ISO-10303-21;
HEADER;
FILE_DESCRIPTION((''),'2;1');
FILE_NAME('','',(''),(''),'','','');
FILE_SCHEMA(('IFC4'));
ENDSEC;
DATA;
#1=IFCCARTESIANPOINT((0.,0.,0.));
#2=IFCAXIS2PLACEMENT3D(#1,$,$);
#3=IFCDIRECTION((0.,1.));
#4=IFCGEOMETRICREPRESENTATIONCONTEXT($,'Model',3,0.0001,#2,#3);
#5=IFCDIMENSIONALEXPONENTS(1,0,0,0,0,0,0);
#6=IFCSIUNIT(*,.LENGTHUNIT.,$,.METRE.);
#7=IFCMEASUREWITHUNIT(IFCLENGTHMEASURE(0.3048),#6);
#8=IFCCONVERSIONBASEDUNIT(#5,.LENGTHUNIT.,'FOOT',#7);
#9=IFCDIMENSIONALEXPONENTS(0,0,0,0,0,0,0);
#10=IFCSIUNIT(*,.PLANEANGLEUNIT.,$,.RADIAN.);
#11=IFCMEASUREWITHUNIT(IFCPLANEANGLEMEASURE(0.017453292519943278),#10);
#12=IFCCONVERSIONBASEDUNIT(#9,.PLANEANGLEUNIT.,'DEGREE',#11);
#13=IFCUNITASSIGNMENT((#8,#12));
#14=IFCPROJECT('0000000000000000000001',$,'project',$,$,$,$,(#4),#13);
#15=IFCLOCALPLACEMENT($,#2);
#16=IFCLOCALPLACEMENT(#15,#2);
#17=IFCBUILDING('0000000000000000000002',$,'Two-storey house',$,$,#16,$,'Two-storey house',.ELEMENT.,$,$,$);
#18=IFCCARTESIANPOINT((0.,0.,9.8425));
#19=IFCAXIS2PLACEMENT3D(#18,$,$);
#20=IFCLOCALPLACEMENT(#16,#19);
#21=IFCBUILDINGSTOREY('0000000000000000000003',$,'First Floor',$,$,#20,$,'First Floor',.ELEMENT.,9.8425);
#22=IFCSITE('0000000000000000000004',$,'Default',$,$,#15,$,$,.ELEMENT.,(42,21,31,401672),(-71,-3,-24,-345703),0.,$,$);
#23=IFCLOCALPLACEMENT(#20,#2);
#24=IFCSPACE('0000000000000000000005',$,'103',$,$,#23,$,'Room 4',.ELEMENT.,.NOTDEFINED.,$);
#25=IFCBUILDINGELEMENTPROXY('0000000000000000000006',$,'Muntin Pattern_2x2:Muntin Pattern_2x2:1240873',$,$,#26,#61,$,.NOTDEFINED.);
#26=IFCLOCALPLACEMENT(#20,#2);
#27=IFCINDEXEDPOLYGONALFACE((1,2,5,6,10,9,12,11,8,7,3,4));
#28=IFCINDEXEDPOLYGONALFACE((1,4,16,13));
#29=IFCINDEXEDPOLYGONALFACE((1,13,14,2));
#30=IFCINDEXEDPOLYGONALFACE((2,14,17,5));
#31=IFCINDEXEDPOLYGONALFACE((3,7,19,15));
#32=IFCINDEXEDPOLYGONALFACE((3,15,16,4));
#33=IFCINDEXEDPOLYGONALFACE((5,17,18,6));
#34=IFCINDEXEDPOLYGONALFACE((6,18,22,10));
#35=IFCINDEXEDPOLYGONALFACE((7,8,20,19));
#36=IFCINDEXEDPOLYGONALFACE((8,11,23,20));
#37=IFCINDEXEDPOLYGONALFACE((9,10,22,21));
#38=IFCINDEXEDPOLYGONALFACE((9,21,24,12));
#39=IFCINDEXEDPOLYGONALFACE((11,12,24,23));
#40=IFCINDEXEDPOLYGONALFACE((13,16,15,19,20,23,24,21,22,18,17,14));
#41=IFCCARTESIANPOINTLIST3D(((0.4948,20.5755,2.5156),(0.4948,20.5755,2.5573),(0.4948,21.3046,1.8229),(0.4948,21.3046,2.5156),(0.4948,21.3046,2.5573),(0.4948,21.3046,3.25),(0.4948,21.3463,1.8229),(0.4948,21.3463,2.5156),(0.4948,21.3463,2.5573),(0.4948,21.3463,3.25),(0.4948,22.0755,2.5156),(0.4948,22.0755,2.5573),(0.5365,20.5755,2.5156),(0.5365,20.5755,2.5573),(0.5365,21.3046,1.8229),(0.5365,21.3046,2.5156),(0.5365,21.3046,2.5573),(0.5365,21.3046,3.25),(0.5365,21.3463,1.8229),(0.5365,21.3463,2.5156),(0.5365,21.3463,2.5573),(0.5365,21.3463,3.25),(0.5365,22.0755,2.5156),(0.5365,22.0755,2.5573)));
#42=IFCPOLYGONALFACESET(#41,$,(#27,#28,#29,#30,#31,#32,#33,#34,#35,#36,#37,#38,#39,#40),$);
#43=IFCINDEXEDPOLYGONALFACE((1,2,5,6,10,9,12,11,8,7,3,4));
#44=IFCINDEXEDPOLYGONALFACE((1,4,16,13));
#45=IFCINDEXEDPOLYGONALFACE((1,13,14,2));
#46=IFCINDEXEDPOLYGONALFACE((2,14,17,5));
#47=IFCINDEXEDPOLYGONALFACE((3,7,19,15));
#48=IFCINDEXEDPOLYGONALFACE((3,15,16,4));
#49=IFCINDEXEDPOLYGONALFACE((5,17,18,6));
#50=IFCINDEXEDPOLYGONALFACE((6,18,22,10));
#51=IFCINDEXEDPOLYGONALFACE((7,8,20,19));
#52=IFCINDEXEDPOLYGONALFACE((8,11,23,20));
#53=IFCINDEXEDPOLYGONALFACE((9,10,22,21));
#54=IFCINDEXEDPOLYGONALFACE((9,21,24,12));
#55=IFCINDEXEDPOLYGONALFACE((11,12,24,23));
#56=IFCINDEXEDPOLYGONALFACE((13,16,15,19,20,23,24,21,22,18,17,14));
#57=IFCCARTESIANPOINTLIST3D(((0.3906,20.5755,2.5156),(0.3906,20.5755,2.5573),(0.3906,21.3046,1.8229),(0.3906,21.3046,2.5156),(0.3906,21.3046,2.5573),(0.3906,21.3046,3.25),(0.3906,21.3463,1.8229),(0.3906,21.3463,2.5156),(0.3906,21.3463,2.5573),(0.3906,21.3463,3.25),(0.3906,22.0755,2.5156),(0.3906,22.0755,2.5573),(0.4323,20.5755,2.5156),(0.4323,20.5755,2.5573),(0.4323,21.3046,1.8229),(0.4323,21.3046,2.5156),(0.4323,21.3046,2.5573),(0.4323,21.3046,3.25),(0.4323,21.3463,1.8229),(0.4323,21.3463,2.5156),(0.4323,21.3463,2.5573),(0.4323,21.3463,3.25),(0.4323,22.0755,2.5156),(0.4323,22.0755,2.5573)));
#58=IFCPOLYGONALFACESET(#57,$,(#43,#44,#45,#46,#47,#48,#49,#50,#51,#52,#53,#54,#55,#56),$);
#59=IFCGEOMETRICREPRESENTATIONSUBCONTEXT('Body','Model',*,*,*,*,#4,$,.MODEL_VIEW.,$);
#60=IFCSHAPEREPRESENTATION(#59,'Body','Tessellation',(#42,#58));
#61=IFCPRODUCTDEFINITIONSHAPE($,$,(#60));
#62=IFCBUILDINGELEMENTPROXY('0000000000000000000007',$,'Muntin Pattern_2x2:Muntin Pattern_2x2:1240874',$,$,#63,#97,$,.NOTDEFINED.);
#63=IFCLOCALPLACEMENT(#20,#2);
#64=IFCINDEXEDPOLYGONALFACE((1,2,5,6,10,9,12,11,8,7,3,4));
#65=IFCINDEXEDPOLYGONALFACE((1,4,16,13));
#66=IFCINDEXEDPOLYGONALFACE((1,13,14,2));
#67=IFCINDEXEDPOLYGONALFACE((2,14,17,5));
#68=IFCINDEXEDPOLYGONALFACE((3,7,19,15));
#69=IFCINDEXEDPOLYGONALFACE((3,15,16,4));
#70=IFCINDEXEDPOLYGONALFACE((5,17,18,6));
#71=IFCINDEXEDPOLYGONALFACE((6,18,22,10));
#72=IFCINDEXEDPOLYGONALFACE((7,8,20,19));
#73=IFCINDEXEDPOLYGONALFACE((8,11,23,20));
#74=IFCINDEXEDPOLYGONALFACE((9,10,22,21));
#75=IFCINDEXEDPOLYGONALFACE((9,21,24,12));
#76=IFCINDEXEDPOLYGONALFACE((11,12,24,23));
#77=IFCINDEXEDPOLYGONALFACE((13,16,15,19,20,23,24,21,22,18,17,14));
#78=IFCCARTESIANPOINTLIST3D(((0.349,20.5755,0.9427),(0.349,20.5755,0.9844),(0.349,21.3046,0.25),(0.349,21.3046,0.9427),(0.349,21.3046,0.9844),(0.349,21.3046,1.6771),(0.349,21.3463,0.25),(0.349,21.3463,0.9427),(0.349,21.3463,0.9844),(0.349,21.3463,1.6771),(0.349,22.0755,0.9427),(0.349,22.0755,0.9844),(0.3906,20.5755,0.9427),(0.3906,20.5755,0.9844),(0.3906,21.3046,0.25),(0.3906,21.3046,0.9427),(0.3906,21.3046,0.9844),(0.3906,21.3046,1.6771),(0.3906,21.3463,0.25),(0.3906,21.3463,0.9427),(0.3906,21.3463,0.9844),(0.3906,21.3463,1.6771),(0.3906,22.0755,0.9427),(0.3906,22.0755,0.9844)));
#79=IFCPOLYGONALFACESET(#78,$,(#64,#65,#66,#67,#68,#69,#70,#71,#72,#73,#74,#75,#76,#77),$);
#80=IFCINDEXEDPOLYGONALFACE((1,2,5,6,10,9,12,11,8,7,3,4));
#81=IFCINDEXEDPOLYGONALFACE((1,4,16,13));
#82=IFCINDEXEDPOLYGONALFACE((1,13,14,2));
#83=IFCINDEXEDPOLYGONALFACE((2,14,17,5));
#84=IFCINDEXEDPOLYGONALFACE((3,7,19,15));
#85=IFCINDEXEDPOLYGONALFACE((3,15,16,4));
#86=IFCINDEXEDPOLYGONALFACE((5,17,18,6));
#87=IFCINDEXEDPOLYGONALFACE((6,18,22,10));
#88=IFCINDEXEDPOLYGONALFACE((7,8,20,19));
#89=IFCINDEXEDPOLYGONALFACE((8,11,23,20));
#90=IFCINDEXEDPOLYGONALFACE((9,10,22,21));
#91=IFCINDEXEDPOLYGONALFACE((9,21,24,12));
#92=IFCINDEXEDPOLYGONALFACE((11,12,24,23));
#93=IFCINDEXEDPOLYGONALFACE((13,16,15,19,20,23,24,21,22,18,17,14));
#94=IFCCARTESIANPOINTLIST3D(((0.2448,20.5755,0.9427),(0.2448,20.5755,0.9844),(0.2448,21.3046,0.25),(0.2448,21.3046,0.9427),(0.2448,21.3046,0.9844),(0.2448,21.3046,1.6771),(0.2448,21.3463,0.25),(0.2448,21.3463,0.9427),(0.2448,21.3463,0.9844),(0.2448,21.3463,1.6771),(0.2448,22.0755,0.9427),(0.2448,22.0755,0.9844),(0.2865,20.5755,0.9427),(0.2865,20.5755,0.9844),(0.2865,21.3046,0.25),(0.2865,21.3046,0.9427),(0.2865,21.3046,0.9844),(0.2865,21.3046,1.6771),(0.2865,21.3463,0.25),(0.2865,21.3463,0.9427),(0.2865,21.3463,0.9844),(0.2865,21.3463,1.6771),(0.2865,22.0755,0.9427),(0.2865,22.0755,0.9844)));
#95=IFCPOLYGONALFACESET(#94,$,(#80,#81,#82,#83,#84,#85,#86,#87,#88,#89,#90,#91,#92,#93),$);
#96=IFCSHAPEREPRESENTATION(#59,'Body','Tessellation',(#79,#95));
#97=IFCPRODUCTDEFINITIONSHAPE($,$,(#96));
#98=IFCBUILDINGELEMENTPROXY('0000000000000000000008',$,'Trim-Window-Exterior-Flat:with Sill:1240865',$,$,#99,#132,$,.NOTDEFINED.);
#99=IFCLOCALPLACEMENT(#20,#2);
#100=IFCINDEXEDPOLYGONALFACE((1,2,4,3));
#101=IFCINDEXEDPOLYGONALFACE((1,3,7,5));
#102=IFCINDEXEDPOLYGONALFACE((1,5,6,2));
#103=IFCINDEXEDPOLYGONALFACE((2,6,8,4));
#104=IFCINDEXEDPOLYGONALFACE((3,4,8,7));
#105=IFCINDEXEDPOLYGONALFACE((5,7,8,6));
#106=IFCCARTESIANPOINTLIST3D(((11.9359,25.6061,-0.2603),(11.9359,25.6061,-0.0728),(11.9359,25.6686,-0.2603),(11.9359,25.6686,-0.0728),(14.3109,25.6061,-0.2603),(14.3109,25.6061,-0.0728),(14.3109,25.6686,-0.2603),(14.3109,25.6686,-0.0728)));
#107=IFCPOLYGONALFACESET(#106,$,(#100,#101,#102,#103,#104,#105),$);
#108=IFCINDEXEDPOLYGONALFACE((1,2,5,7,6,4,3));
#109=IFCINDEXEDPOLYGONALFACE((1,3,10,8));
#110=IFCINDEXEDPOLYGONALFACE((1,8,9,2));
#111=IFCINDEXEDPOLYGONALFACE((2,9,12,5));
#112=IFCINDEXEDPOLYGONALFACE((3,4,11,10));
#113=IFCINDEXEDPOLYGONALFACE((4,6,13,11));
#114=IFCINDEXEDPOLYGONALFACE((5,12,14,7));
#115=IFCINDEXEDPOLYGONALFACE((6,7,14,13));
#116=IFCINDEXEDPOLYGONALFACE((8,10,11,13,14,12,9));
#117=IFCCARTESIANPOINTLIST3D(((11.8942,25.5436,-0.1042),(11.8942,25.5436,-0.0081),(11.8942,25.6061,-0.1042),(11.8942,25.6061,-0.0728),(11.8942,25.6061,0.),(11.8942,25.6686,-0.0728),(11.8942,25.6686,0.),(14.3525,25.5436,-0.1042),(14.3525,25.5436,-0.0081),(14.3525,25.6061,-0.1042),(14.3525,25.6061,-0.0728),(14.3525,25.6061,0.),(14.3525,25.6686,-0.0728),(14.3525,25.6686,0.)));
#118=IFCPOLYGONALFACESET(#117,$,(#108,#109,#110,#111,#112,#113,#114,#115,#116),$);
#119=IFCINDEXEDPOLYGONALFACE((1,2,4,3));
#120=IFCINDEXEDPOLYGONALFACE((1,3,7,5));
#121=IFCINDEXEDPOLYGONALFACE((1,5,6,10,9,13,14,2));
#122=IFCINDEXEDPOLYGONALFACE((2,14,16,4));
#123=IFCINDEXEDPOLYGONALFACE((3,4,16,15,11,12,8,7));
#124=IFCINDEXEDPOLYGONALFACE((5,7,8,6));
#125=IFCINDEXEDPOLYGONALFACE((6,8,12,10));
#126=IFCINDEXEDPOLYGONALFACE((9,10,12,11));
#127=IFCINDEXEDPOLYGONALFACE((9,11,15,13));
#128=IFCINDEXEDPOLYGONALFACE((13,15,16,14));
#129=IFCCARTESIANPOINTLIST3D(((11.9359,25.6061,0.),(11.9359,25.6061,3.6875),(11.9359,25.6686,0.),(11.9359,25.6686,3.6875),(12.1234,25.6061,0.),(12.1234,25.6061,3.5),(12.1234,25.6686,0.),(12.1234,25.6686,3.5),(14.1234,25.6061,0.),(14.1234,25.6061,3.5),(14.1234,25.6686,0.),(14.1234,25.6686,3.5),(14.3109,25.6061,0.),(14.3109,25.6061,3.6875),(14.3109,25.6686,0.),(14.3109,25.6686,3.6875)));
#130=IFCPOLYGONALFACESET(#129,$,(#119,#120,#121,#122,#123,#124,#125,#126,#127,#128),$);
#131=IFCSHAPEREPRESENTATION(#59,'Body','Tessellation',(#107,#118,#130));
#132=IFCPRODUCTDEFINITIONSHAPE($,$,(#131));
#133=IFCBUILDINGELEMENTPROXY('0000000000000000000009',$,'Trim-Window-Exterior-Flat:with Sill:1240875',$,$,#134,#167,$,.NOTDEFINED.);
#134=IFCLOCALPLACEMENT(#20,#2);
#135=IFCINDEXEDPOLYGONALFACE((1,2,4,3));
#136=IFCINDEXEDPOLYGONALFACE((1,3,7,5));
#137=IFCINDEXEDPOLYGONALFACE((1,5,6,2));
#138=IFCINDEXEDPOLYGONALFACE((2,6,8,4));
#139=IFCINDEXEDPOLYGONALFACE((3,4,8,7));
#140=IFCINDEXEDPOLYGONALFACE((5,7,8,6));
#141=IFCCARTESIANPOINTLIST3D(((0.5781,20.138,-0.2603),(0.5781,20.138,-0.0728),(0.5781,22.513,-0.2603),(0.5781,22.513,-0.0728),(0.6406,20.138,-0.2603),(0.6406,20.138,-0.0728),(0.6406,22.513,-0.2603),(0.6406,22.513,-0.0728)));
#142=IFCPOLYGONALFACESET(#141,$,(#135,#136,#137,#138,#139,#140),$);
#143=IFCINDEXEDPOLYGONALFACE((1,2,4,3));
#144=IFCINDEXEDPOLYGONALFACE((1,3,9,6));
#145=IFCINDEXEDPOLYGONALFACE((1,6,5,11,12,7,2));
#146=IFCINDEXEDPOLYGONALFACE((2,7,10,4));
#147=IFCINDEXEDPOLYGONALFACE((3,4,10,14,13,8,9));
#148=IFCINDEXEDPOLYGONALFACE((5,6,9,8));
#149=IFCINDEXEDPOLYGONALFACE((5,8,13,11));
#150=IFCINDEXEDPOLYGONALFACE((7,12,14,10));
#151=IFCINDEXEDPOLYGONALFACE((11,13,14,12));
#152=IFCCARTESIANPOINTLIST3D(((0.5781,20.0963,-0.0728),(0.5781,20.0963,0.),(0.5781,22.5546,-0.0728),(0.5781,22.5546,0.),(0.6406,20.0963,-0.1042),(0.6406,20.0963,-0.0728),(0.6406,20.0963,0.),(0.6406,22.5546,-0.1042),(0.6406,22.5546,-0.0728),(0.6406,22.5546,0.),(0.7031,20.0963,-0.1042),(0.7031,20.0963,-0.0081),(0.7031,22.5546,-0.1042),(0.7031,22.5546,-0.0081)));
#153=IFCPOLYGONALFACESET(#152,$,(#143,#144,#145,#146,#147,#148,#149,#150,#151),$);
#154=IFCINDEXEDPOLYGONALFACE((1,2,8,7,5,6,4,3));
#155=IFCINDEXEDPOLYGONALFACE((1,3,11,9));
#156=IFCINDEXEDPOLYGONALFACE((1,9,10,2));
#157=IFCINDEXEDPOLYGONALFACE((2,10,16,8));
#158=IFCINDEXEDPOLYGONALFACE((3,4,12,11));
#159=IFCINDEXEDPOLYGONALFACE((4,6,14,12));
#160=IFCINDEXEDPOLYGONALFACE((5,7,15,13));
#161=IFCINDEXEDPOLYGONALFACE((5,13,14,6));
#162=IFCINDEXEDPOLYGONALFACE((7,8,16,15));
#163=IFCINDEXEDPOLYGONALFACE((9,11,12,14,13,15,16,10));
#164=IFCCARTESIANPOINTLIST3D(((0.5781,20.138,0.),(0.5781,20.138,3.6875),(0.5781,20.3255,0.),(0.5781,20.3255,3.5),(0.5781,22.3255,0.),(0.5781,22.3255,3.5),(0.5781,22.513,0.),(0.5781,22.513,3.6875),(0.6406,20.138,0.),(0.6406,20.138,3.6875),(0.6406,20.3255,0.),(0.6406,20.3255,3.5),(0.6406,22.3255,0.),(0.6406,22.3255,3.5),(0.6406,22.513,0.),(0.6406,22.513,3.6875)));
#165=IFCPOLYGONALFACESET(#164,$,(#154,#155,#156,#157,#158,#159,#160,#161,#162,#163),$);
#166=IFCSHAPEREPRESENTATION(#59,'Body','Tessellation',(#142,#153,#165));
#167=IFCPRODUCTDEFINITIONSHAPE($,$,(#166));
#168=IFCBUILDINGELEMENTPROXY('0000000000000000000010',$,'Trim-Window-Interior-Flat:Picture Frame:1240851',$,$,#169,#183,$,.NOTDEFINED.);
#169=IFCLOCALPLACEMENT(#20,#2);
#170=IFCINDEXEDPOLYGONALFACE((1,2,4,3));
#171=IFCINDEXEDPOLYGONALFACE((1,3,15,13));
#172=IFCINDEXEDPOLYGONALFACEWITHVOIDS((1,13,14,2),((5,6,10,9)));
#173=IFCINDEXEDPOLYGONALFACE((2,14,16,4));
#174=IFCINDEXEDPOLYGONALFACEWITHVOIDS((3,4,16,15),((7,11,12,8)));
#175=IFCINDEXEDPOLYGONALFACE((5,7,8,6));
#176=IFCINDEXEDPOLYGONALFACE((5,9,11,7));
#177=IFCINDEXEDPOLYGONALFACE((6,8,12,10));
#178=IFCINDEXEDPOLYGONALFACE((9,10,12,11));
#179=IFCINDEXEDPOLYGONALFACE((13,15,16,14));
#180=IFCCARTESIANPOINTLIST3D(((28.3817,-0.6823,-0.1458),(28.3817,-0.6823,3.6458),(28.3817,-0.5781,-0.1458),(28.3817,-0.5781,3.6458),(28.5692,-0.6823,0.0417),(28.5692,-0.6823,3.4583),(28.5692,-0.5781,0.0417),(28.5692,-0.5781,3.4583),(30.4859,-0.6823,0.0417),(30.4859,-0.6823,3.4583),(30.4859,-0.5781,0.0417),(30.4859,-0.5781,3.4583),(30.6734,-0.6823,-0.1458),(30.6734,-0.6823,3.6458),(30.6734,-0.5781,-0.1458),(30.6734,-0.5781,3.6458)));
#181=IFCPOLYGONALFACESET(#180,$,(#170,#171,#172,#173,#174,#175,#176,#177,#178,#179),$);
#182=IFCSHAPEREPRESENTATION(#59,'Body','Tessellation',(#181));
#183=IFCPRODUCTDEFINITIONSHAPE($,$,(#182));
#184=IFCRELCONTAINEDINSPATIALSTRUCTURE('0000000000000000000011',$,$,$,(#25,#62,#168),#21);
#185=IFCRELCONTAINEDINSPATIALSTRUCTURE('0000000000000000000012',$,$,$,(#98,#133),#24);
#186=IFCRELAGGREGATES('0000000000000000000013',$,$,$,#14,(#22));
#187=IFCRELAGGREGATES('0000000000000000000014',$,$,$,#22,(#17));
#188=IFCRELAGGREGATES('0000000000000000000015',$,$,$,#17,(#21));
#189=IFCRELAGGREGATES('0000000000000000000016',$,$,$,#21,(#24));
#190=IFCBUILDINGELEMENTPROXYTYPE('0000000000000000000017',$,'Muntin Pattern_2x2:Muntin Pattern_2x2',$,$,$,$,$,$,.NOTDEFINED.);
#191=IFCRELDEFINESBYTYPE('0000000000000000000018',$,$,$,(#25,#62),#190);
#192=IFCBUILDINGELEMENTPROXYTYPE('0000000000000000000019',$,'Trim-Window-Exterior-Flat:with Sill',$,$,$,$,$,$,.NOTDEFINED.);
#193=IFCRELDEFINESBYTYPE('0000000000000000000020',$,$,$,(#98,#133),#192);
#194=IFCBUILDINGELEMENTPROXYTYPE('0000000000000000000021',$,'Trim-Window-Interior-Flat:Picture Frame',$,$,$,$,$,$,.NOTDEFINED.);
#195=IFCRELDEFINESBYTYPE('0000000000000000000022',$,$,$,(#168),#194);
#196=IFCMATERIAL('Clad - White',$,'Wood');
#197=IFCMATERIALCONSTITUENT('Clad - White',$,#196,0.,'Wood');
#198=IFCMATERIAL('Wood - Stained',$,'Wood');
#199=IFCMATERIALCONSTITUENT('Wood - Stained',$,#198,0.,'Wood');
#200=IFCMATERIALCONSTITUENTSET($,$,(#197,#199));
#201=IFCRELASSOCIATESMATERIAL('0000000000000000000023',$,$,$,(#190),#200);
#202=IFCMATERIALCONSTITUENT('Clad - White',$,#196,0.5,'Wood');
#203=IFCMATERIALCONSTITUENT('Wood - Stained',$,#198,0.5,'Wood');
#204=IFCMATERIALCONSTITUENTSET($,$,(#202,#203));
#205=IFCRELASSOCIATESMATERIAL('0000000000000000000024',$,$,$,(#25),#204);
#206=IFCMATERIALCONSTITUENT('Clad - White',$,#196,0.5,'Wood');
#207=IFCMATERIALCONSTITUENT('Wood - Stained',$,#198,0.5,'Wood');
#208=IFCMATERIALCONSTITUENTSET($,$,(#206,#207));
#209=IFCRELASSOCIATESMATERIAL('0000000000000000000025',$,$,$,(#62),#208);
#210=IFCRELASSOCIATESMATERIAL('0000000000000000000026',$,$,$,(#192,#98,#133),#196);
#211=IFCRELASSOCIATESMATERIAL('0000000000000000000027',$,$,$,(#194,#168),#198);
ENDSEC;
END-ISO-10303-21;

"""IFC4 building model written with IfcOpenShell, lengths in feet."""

from ifc_helpers import new_model, entity, si_unit, converted_unit, direction, frame, origin, place, context, subcontext, project, spatial, indexed_curve, outline, extrude, source, transform, mapped, material, constituent, constituent_set, type_object, type_shapes, element, save


model = new_model("IFC4")

# Units and contexts
model_context = context("Model", 3, precision=0.0001, world=origin(), true_north=direction((0.0, 1.0)))
body_context = subcontext(model_context, "Body", "Model", "MODEL_VIEW")
ifc_project = project(units=[converted_unit("LENGTHUNIT", "FOOT", entity("IfcLengthMeasure", 0.3048), si_unit("LENGTHUNIT", "METRE"), dimensions=[1, 0, 0, 0, 0, 0, 0]), converted_unit("PLANEANGLEUNIT", "DEGREE", entity("IfcPlaneAngleMeasure", 0.017453292519943278), si_unit("PLANEANGLEUNIT", "RADIAN"), dimensions=[0, 0, 0, 0, 0, 0, 0])], contexts=[model_context])

# Site, building, storey
site_placement = place(None, origin())
site = spatial("IfcSite", under=ifc_project, at=site_placement, Name="Default", CompositionType="ELEMENT", RefLatitude=(42, 21, 31, 401672), RefLongitude=(-71, -3, -24, -345703), RefElevation=0.0)
building_placement = place(site_placement, origin())
building = spatial("IfcBuilding", under=site, at=building_placement, Name="Two-storey house", LongName="Two-storey house", CompositionType="ELEMENT")
storey_placement = place(building_placement, frame((0.0, 0.0, 9.8425)))
storey = spatial("IfcBuildingStorey", under=building, at=storey_placement, Name="First Floor", LongName="First Floor", CompositionType="ELEMENT", Elevation=9.8425)

# Shared definitions
ifc_material_1 = material(Name="Wood - Stained", Category="Wood")

# Building element proxies
ifc_material_2 = material(Name="Clad - White", Category="Wood")
ifc_constituent_1 = constituent(ifc_material_2, Name="Clad - White", Category="Wood", fraction=0.0)
ifc_constituent_2 = constituent(ifc_material_1, Name="Wood - Stained", Category="Wood", fraction=0.0)
ifc_constituent_set_1 = constituent_set(constituents=[ifc_constituent_1, ifc_constituent_2])
building_element_proxy_type_1 = type_object("IfcBuildingElementProxyType", Name="Muntin Pattern_2x2:Muntin Pattern_2x2", PredefinedType="NOTDEFINED", material=ifc_constituent_set_1)
shared_shape_1 = source(origin(), body_context, "Body", "SweptSolid", [
    extrude(outline(indexed_curve([(0.0208, -0.0208), (0.7135, -0.0208), (0.7135, 0.0208), (0.0208, 0.0208), (0.0208, 0.75), (-0.0208, 0.75), (-0.0208, 0.0208), (-0.7135, 0.0208), (-0.7135, -0.0208), (-0.0208, -0.0208), (-0.0208, -0.75), (0.0208, -0.75), (0.0208, -0.0208)], self_intersect=False)), frame((0.0, 0.0312, 0.7135), z_axis=(0.0, 1.0, 0.0), x_axis=(0.0, 0.0, 1.0)), (0.0, 0.0, 1.0), 0.0417),
    extrude(outline(indexed_curve([(0.0208, -0.0208), (0.7135, -0.0208), (0.7135, 0.0208), (0.0208, 0.0208), (0.0208, 0.75), (-0.0208, 0.75), (-0.0208, 0.0208), (-0.7135, 0.0208), (-0.7135, -0.0208), (-0.0208, -0.0208), (-0.0208, -0.75), (0.0208, -0.75), (0.0208, -0.0208)], self_intersect=False)), frame((0.0, -0.0729, 0.7135), z_axis=(0.0, 1.0, 0.0), x_axis=(0.0, 0.0, 1.0)), (0.0, 0.0, 1.0), 0.0417),
])
type_shapes(building_element_proxy_type_1, [shared_shape_1])
ifc_constituent_3 = constituent(ifc_material_2, Name="Clad - White", Category="Wood", fraction=0.5)
ifc_constituent_4 = constituent(ifc_material_1, Name="Wood - Stained", Category="Wood", fraction=0.5)
ifc_constituent_set_2 = constituent_set(constituents=[ifc_constituent_3, ifc_constituent_4])
proxy_1_placement = place(storey_placement, frame((0.4635, 21.3255, 1.8229), z_axis=(0.0, 0.0, 1.0), x_axis=(0.0, -1.0, 0.0)))
element("IfcBuildingElementProxy", 1, at=proxy_1_placement, inside=storey, type_object=building_element_proxy_type_1, material=ifc_constituent_set_2, Name="Muntin Pattern_2x2:Muntin Pattern_2x2:1240873", PredefinedType="NOTDEFINED", context=body_context, shape_type="MappedRepresentation", body=[
    mapped(shared_shape_1, transform((0.0, 0.0, 0.0), scale=1.0)),
])
ifc_constituent_5 = constituent(ifc_material_2, Name="Clad - White", Category="Wood", fraction=0.5)
ifc_constituent_6 = constituent(ifc_material_1, Name="Wood - Stained", Category="Wood", fraction=0.5)
ifc_constituent_set_3 = constituent_set(constituents=[ifc_constituent_5, ifc_constituent_6])
proxy_2_placement = place(storey_placement, frame((0.3177, 21.3255, 0.25), z_axis=(0.0, 0.0, 1.0), x_axis=(0.0, -1.0, 0.0)))
element("IfcBuildingElementProxy", 2, at=proxy_2_placement, inside=storey, type_object=building_element_proxy_type_1, material=ifc_constituent_set_3, Name="Muntin Pattern_2x2:Muntin Pattern_2x2:1240874", PredefinedType="NOTDEFINED", context=body_context, shape_type="MappedRepresentation", body=[
    mapped(shared_shape_1, transform((0.0, 0.0, 0.0), scale=1.0)),
])

# Shared definitions
space_placement = place(storey_placement, origin())
space = spatial("IfcSpace", under=storey, at=space_placement, Name="103", LongName="Room 4", CompositionType="ELEMENT", PredefinedType="NOTDEFINED")

# Building element proxies
building_element_proxy_type_2 = type_object("IfcBuildingElementProxyType", Name="Trim-Window-Exterior-Flat:with Sill", PredefinedType="NOTDEFINED", material=ifc_material_2)
shared_shape_2 = source(origin(), body_context, "Body", "SweptSolid", [
    extrude(outline(indexed_curve([(-1.1875, -0.0938), (1.1875, -0.0938), (1.1875, 0.0938), (-1.1875, 0.0938), (-1.1875, -0.0938)], self_intersect=False)), frame((0.0, -3.6665, 0.0), z_axis=(0.0, 0.0, 1.0), x_axis=(-1.0, 0.0, 0.0)), (0.0, 0.0, 1.0), 0.0625),
    extrude(outline(indexed_curve([(-0.0625, -0.0525), (0.0, -0.0525), (0.0, -0.0211), (0.0625, -0.0211), (0.0625, 0.0517), (0.0, 0.0517), (-0.0625, 0.0436), (-0.0625, -0.0525)], self_intersect=False)), frame((-1.2292, -3.5517, 0.0625), z_axis=(1.0, 0.0, 0.0), x_axis=(0.0, 0.0, -1.0)), (0.0, 0.0, 1.0), 2.4583),
    extrude(outline(indexed_curve([(-1.8906, -1.1875), (1.7969, -1.1875), (1.7969, -1.0), (-1.7031, -1.0), (-1.7031, 1.0), (1.7969, 1.0), (1.7969, 1.1875), (-1.8906, 1.1875), (-1.8906, -1.1875)], self_intersect=False)), frame((0.0, -1.7031, 0.0), z_axis=(0.0, 0.0, 1.0), x_axis=(0.0, -1.0, 0.0)), (0.0, 0.0, 1.0), 0.0625),
])
type_shapes(building_element_proxy_type_2, [shared_shape_2])
for number, where, z_axis, x_axis, name in (
    (3, (13.1234, 25.6686, 3.5), (0.0, -1.0, 0.0), (1.0, 0.0, 0.0), "Trim-Window-Exterior-Flat:with Sill:1240865"),
    (4, (0.5781, 21.3255, 3.5), (1.0, 0.0, 0.0), (0.0, 1.0, 0.0), "Trim-Window-Exterior-Flat:with Sill:1240875"),
):
    element("IfcBuildingElementProxy", number, at=place(space_placement, frame(where, z_axis=z_axis, x_axis=x_axis)), inside=space, type_object=building_element_proxy_type_2, material=ifc_material_2, Name=name, PredefinedType="NOTDEFINED", context=body_context, shape_type="MappedRepresentation", body=[
        mapped(shared_shape_2, transform((0.0, 0.0, 0.0), scale=1.0)),
    ])
building_element_proxy_type_3 = type_object("IfcBuildingElementProxyType", Name="Trim-Window-Interior-Flat:Picture Frame", PredefinedType="NOTDEFINED", material=ifc_material_1)
shared_shape_3 = source(origin(), body_context, "Body", "SweptSolid", [
    extrude(outline(indexed_curve([(-1.1458, -1.8958), (1.1458, -1.8958), (1.1458, 1.8958), (-1.1458, 1.8958), (-1.1458, -1.8958)], self_intersect=False), holes=[indexed_curve([(-0.9583, -1.7083), (-0.9583, 1.7083), (0.9583, 1.7083), (0.9583, -1.7083), (-0.9583, -1.7083)], self_intersect=False)]), frame((0.0, -1.75, 0.0), z_axis=(0.0, 0.0, 1.0), x_axis=(-1.0, 0.0, 0.0)), (0.0, 0.0, 1.0), 0.1042),
])
type_shapes(building_element_proxy_type_3, [shared_shape_3])
for number, where, z_axis, x_axis, name in (
    (5, (29.5276, -0.5781, 3.5), (0.0, -1.0, 0.0), (1.0, 0.0, 0.0), "Trim-Window-Interior-Flat:Picture Frame:1240851"),
):
    element("IfcBuildingElementProxy", number, at=place(storey_placement, frame(where, z_axis=z_axis, x_axis=x_axis)), inside=storey, type_object=building_element_proxy_type_3, material=ifc_material_1, Name=name, PredefinedType="NOTDEFINED", context=body_context, shape_type="MappedRepresentation", body=[
        mapped(shared_shape_3, transform((0.0, 0.0, 0.0), scale=1.0)),
    ])

save(model, "model.ifc")
